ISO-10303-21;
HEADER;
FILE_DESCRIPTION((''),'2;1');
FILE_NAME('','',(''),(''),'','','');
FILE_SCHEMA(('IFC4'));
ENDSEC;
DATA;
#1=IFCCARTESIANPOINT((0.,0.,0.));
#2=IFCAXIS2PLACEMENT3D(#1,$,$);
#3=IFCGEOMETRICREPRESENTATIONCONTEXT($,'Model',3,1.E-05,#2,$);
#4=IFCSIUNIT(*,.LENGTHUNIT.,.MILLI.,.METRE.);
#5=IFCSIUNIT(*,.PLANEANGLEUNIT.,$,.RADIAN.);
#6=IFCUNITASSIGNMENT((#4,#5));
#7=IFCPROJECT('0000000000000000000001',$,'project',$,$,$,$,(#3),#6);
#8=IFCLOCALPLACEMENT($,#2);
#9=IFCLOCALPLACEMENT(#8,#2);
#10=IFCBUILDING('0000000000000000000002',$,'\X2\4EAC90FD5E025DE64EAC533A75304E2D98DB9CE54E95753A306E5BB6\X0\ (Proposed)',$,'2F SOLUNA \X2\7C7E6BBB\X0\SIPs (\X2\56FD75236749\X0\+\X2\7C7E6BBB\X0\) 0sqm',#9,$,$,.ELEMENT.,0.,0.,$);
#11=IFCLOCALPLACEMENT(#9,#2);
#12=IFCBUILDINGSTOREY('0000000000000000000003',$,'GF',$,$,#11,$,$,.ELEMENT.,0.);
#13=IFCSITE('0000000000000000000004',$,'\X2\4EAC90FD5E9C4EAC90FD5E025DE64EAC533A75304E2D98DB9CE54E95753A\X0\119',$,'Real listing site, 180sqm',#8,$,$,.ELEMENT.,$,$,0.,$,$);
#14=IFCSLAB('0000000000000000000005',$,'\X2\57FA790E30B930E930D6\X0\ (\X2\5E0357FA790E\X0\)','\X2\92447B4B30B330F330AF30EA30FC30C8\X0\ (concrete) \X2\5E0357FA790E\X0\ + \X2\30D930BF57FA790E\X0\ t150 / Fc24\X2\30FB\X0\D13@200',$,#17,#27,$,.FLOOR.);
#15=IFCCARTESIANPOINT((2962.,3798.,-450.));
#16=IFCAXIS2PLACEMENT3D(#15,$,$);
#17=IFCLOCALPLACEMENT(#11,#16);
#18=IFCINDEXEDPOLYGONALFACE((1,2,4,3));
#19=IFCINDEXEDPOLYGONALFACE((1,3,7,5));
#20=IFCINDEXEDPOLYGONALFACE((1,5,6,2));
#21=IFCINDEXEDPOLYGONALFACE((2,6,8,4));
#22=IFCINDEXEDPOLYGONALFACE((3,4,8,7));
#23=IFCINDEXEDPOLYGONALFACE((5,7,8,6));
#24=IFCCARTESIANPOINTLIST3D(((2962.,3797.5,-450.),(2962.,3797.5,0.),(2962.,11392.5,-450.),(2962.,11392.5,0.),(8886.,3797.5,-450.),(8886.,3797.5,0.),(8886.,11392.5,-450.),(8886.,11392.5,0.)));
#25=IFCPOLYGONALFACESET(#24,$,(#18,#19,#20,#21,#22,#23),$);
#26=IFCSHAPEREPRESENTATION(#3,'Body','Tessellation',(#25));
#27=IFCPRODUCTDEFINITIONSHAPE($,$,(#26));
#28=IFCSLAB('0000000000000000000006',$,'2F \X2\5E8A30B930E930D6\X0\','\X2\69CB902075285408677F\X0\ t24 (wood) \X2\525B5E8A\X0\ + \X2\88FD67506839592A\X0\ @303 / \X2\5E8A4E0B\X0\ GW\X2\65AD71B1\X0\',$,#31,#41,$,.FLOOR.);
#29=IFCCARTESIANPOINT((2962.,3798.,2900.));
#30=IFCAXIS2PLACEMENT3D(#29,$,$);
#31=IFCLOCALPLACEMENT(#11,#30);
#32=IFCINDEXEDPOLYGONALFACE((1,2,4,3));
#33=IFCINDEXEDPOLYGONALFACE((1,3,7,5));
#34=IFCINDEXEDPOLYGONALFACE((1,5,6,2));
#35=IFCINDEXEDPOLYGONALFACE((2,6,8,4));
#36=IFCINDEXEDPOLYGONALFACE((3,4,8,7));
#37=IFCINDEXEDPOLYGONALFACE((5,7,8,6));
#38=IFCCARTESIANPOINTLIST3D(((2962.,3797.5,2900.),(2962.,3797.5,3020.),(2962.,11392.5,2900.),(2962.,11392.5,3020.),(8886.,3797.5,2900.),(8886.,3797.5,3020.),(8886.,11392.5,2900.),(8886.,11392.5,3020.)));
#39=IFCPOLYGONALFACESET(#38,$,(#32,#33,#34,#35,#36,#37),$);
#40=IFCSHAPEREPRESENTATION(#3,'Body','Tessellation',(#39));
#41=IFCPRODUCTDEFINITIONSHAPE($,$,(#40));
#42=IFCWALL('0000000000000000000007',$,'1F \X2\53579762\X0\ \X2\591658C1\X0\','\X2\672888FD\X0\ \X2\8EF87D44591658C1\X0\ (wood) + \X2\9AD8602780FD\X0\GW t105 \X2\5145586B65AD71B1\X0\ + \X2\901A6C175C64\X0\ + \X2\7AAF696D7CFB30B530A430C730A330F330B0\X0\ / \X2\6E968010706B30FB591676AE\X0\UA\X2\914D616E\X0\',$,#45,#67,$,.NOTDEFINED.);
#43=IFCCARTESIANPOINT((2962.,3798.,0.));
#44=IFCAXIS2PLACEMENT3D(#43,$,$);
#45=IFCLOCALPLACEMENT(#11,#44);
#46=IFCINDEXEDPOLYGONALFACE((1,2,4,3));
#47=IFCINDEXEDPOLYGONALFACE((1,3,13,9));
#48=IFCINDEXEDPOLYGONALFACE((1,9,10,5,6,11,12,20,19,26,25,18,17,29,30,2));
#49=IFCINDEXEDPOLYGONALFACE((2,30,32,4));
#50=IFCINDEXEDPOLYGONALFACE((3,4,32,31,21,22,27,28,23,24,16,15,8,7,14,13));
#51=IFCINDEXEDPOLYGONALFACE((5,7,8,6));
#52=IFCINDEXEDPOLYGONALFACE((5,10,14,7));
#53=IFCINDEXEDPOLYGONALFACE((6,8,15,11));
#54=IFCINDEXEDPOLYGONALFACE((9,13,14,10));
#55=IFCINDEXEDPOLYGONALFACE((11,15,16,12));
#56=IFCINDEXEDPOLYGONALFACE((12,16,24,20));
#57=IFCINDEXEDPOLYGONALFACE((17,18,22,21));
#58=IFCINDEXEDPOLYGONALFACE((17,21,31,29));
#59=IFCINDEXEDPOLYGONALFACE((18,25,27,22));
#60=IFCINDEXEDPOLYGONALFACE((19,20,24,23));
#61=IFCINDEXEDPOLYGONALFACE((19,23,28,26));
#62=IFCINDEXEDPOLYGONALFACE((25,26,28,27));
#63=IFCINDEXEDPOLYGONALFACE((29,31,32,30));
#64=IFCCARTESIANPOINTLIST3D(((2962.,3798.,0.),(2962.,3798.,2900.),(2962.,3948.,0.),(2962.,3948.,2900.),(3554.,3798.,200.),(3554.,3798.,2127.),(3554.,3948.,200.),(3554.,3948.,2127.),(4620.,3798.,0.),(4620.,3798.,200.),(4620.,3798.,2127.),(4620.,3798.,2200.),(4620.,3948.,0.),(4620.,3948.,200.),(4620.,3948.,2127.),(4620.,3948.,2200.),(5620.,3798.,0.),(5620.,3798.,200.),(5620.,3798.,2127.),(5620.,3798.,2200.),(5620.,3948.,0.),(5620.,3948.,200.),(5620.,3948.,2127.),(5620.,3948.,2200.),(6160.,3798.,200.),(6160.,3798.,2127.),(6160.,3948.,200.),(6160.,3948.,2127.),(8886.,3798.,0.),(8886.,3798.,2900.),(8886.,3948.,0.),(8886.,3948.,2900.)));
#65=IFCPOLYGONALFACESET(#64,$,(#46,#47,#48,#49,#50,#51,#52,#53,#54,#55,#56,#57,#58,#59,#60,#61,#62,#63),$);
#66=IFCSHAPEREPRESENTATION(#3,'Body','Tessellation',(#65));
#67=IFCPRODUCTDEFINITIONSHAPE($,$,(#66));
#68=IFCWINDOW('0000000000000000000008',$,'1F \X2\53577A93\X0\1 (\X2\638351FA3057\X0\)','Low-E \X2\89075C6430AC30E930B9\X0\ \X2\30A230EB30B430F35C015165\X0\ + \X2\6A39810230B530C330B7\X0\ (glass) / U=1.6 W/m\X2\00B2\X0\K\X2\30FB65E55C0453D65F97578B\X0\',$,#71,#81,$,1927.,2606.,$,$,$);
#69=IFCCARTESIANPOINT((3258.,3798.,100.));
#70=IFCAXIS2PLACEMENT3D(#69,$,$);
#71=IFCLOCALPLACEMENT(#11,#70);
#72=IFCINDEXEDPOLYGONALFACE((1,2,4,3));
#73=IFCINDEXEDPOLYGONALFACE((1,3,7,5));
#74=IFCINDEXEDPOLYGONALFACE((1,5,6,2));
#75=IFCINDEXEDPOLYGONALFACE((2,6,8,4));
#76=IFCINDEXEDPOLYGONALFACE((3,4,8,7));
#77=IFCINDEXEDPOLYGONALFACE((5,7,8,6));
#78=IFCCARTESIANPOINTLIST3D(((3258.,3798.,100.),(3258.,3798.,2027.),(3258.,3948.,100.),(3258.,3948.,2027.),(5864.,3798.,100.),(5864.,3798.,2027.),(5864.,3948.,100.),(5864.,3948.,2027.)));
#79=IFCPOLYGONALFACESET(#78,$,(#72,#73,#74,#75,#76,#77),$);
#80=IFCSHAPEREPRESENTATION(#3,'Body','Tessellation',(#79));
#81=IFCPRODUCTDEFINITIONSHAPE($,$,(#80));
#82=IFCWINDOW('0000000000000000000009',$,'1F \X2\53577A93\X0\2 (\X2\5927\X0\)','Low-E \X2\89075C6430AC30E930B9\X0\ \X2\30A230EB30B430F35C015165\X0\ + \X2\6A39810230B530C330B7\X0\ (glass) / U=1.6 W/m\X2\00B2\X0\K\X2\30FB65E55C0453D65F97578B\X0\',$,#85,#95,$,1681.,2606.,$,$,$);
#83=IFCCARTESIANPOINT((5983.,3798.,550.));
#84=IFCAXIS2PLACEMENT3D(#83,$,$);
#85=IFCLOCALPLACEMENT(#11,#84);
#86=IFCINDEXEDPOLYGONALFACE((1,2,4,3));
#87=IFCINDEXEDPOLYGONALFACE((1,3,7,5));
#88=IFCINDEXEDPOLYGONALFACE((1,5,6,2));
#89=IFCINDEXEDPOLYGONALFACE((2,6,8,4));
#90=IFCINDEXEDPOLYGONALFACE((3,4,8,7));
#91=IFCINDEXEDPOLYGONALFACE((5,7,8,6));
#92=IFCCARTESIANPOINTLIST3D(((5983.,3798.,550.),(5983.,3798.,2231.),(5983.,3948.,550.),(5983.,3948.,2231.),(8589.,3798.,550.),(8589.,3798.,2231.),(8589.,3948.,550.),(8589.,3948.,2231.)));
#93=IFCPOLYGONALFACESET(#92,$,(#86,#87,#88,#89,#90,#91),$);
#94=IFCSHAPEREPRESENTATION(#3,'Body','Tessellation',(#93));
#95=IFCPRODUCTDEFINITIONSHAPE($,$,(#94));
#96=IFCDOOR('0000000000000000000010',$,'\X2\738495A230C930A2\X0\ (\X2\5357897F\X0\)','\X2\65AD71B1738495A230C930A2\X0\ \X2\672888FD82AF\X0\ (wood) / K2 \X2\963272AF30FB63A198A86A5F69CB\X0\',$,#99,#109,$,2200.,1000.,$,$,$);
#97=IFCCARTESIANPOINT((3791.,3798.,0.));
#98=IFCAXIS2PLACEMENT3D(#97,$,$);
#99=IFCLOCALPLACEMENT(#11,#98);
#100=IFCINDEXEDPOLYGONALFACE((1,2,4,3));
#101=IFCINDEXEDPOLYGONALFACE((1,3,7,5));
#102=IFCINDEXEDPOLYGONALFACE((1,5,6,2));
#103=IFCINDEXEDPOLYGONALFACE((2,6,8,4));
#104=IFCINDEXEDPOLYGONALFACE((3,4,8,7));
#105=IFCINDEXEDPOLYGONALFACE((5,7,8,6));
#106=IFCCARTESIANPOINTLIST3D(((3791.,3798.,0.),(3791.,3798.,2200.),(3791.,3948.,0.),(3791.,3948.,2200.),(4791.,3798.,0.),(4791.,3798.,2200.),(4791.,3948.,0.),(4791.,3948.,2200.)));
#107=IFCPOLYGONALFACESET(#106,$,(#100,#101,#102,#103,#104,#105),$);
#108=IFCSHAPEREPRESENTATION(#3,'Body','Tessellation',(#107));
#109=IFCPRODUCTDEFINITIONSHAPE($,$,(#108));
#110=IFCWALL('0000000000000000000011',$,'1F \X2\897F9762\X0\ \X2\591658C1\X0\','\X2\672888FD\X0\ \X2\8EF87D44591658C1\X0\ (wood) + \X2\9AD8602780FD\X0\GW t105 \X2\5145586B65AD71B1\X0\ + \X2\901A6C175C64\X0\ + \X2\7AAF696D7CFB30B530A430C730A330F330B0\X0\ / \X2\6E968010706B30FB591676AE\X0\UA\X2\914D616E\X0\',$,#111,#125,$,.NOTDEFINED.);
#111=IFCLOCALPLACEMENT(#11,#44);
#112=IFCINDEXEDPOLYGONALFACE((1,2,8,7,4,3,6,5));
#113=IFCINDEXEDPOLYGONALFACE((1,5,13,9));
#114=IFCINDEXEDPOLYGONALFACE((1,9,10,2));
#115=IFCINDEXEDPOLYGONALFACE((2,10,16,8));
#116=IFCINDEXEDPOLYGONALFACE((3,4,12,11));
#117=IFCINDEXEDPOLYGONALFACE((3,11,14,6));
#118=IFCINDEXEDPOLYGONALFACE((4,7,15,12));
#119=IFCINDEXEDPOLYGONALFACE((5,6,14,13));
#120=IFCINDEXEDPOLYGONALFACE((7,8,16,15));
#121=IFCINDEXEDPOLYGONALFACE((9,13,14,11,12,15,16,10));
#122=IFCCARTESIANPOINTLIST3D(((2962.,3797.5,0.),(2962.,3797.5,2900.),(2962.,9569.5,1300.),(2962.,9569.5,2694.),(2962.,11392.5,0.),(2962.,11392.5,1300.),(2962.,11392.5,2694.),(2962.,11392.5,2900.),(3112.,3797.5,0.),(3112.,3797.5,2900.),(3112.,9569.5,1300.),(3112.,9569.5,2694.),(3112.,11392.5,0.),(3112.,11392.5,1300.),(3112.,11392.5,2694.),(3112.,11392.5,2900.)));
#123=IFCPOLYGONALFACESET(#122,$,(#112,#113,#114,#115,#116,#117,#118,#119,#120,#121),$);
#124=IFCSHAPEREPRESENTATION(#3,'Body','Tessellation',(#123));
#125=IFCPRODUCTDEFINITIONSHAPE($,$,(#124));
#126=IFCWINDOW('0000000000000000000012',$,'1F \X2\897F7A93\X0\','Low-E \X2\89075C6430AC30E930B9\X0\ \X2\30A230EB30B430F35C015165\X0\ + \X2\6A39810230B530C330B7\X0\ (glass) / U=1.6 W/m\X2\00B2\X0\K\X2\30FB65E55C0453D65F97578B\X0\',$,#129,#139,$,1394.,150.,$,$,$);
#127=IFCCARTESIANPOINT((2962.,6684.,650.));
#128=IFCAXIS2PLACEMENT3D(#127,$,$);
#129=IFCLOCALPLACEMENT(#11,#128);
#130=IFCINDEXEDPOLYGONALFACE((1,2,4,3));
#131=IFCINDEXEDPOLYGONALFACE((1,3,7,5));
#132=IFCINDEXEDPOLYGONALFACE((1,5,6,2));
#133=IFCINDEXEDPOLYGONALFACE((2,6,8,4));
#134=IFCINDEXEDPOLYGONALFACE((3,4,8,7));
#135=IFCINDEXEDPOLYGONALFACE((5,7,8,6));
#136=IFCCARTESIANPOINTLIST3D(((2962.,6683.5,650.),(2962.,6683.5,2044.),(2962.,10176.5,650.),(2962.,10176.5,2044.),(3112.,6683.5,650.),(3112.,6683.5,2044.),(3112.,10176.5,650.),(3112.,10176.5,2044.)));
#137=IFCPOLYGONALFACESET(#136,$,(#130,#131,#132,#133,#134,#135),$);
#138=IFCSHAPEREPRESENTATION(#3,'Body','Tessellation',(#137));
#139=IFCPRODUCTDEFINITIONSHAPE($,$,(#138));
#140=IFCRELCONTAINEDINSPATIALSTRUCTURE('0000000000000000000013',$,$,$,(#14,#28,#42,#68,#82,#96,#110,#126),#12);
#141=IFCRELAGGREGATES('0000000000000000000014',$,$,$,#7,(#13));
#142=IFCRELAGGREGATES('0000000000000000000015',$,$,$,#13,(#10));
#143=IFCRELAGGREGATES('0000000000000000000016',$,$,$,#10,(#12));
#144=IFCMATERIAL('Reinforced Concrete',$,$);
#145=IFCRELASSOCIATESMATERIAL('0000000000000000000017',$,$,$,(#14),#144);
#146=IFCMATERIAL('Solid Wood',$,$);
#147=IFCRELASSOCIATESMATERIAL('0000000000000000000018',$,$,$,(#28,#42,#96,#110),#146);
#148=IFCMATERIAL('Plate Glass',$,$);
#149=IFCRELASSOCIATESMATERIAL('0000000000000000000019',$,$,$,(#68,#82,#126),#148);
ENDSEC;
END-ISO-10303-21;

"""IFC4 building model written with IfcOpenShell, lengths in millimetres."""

from ifc_helpers import new_model, si_unit, frame, frame_2d, origin, place, context, project, spatial, rectangle, extrude, material, element, fill, save


model = new_model("IFC4")

# Units and contexts
model_context = context("Model", 3, precision=1e-05, world=origin())
ifc_project = project(units=[si_unit("LENGTHUNIT", "METRE", prefix="MILLI"), si_unit("PLANEANGLEUNIT", "RADIAN")], contexts=[model_context])

# Site, building, storey
site_placement = place(None, origin())
site = spatial("IfcSite", under=ifc_project, at=site_placement, Name="京都府京都市左京区田中飛鳥井町119", ObjectType="Real listing site, 180sqm", CompositionType="ELEMENT", RefElevation=0.0)
building_placement = place(site_placement, origin())
building = spatial("IfcBuilding", under=site, at=building_placement, Name="京都市左京区田中飛鳥井町の家 (Proposed)", ObjectType="2F SOLUNA 籾殻SIPs (国産杉+籾殻) 0sqm", CompositionType="ELEMENT", ElevationOfRefHeight=0.0, ElevationOfTerrain=0.0)
storey_placement = place(building_placement, origin())
storey = spatial("IfcBuildingStorey", under=building, at=storey_placement, Name="GF", CompositionType="ELEMENT", Elevation=0.0)

# Slabs
ifc_material_1 = material(Name="Reinforced Concrete")
slab_1_placement = place(storey_placement, frame((2962.0, 3798.0, -450.0)))
element("IfcSlab", 1, at=slab_1_placement, inside=storey, material=ifc_material_1, Name="基礎スラブ (布基礎)", Description="鉄筋コンクリート (concrete) 布基礎 + ベタ基礎 t150 / Fc24・D13@200", PredefinedType="FLOOR", context=model_context, shape_type="SweptSolid", body=[
    extrude(rectangle(XDim=5924.0, YDim=7595.0, at=frame_2d((2962.0, 3797.0))), frame((2962.0, 3798.0, -450.0)), (0.0, 0.0, 1.0), 450.0),
])
ifc_material_2 = material(Name="Solid Wood")
slab_2_placement = place(storey_placement, frame((2962.0, 3798.0, 2900.0)))
element("IfcSlab", 2, at=slab_2_placement, inside=storey, material=ifc_material_2, Name="2F 床スラブ", Description="構造用合板 t24 (wood) 剛床 + 製材根太 @303 / 床下 GW断熱", PredefinedType="FLOOR", context=model_context, shape_type="SweptSolid", body=[
    extrude(rectangle(XDim=5924.0, YDim=7595.0, at=frame_2d((2962.0, 3797.0))), frame((2962.0, 3798.0, 2900.0)), (0.0, 0.0, 1.0), 120.0),
])

# Wall, openings, windows, door
wall_1_placement = place(storey_placement, frame((2962.0, 3798.0, 0.0)))
wall_1 = element("IfcWall", 3, at=wall_1_placement, inside=storey, material=ifc_material_2, Name="1F 南面 外壁", Description="木製 軸組外壁 (wood) + 高性能GW t105 充填断熱 + 通気層 + 窯業系サイディング / 準耐火・外皮UA配慮", PredefinedType="NOTDEFINED", context=model_context, shape_type="SweptSolid", body=[
    extrude(rectangle(XDim=5924.0, YDim=150.0, at=frame_2d((2962.0, 75.0))), frame((2962.0, 3798.0, 0.0)), (0.0, 0.0, 1.0), 2900.0),
])
opening_1_placement = place(storey_placement, frame((3258.0, 3798.0, 100.0)))
opening_1 = element("IfcOpeningElement", 4, at=opening_1_placement, cuts=wall_1, PredefinedType="NOTDEFINED", context=model_context, shape_type="SweptSolid", body=[
    extrude(rectangle(XDim=2606.0, YDim=150.0, at=frame_2d((1303.0, 75.0))), frame((3258.0, 3798.0, 100.0)), (0.0, 0.0, 1.0), 1927.0),
])
opening_2_placement = place(storey_placement, frame((5983.0, 3798.0, 550.0)))
opening_2 = element("IfcOpeningElement", 5, at=opening_2_placement, cuts=wall_1, PredefinedType="NOTDEFINED", context=model_context, shape_type="SweptSolid", body=[
    extrude(rectangle(XDim=2606.0, YDim=150.0, at=frame_2d((1303.0, 75.0))), frame((5983.0, 3798.0, 550.0)), (0.0, 0.0, 1.0), 1681.0),
])
opening_3_placement = place(storey_placement, frame((3791.0, 3798.0, 0.0)))
opening_3 = element("IfcOpeningElement", 6, at=opening_3_placement, cuts=wall_1, PredefinedType="NOTDEFINED", context=model_context, shape_type="SweptSolid", body=[
    extrude(rectangle(XDim=1000.0, YDim=150.0, at=frame_2d((500.0, 75.0))), frame((3791.0, 3798.0, 0.0)), (0.0, 0.0, 1.0), 2200.0),
])
ifc_material_3 = material(Name="Plate Glass")
window_1_placement = place(storey_placement, frame((3258.0, 3798.0, 100.0)))
window_1 = element("IfcWindow", 7, at=window_1_placement, inside=storey, material=ifc_material_3, Name="1F 南窓1 (掃出し)", Description="Low-E 複層ガラス アルゴン封入 + 樹脂サッシ (glass) / U=1.6 W/m²K・日射取得型", OverallHeight=1927.0, OverallWidth=2606.0, context=model_context, shape_type="SweptSolid", body=[
    extrude(rectangle(XDim=2606.0, YDim=150.0, at=frame_2d((1303.0, 75.0))), frame((3258.0, 3798.0, 100.0)), (0.0, 0.0, 1.0), 1927.0),
])
fill(opening_1, window_1)
window_2_placement = place(storey_placement, frame((5983.0, 3798.0, 550.0)))
window_2 = element("IfcWindow", 8, at=window_2_placement, inside=storey, material=ifc_material_3, Name="1F 南窓2 (大)", Description="Low-E 複層ガラス アルゴン封入 + 樹脂サッシ (glass) / U=1.6 W/m²K・日射取得型", OverallHeight=1681.0, OverallWidth=2606.0, context=model_context, shape_type="SweptSolid", body=[
    extrude(rectangle(XDim=2606.0, YDim=150.0, at=frame_2d((1303.0, 75.0))), frame((5983.0, 3798.0, 550.0)), (0.0, 0.0, 1.0), 1681.0),
])
fill(opening_2, window_2)
door_placement = place(storey_placement, frame((3791.0, 3798.0, 0.0)))
door = element("IfcDoor", 9, at=door_placement, inside=storey, material=ifc_material_2, Name="玄関ドア (南西)", Description="断熱玄関ドア 木製芯 (wood) / K2 防犯・採風機構", OverallHeight=2200.0, OverallWidth=1000.0, context=model_context, shape_type="SweptSolid", body=[
    extrude(rectangle(XDim=1000.0, YDim=150.0, at=frame_2d((500.0, 75.0))), frame((3791.0, 3798.0, 0.0)), (0.0, 0.0, 1.0), 2200.0),
])
fill(opening_3, door)

# Wall, opening, window
wall_2_placement = place(storey_placement, frame((2962.0, 3798.0, 0.0)))
wall_2 = element("IfcWall", 10, at=wall_2_placement, inside=storey, material=ifc_material_2, Name="1F 西面 外壁", Description="木製 軸組外壁 (wood) + 高性能GW t105 充填断熱 + 通気層 + 窯業系サイディング / 準耐火・外皮UA配慮", PredefinedType="NOTDEFINED", context=model_context, shape_type="SweptSolid", body=[
    extrude(rectangle(XDim=150.0, YDim=7595.0, at=frame_2d((75.0, 3797.0))), frame((2962.0, 3798.0, 0.0)), (0.0, 0.0, 1.0), 2900.0),
])
opening_4_placement = place(storey_placement, frame((2962.0, 6684.0, 650.0)))
opening_4 = element("IfcOpeningElement", 11, at=opening_4_placement, cuts=wall_2, PredefinedType="NOTDEFINED", context=model_context, shape_type="SweptSolid", body=[
    extrude(rectangle(XDim=150.0, YDim=3493.0, at=frame_2d((75.0, 1746.0))), frame((2962.0, 6684.0, 650.0)), (0.0, 0.0, 1.0), 1394.0),
])
window_3_placement = place(storey_placement, frame((2962.0, 6684.0, 650.0)))
window_3 = element("IfcWindow", 12, at=window_3_placement, inside=storey, material=ifc_material_3, Name="1F 西窓", Description="Low-E 複層ガラス アルゴン封入 + 樹脂サッシ (glass) / U=1.6 W/m²K・日射取得型", OverallHeight=1394.0, OverallWidth=150.0, context=model_context, shape_type="SweptSolid", body=[
    extrude(rectangle(XDim=150.0, YDim=3493.0, at=frame_2d((75.0, 1746.0))), frame((2962.0, 6684.0, 650.0)), (0.0, 0.0, 1.0), 1394.0),
])
fill(opening_4, window_3)

save(model, "model.ifc")
